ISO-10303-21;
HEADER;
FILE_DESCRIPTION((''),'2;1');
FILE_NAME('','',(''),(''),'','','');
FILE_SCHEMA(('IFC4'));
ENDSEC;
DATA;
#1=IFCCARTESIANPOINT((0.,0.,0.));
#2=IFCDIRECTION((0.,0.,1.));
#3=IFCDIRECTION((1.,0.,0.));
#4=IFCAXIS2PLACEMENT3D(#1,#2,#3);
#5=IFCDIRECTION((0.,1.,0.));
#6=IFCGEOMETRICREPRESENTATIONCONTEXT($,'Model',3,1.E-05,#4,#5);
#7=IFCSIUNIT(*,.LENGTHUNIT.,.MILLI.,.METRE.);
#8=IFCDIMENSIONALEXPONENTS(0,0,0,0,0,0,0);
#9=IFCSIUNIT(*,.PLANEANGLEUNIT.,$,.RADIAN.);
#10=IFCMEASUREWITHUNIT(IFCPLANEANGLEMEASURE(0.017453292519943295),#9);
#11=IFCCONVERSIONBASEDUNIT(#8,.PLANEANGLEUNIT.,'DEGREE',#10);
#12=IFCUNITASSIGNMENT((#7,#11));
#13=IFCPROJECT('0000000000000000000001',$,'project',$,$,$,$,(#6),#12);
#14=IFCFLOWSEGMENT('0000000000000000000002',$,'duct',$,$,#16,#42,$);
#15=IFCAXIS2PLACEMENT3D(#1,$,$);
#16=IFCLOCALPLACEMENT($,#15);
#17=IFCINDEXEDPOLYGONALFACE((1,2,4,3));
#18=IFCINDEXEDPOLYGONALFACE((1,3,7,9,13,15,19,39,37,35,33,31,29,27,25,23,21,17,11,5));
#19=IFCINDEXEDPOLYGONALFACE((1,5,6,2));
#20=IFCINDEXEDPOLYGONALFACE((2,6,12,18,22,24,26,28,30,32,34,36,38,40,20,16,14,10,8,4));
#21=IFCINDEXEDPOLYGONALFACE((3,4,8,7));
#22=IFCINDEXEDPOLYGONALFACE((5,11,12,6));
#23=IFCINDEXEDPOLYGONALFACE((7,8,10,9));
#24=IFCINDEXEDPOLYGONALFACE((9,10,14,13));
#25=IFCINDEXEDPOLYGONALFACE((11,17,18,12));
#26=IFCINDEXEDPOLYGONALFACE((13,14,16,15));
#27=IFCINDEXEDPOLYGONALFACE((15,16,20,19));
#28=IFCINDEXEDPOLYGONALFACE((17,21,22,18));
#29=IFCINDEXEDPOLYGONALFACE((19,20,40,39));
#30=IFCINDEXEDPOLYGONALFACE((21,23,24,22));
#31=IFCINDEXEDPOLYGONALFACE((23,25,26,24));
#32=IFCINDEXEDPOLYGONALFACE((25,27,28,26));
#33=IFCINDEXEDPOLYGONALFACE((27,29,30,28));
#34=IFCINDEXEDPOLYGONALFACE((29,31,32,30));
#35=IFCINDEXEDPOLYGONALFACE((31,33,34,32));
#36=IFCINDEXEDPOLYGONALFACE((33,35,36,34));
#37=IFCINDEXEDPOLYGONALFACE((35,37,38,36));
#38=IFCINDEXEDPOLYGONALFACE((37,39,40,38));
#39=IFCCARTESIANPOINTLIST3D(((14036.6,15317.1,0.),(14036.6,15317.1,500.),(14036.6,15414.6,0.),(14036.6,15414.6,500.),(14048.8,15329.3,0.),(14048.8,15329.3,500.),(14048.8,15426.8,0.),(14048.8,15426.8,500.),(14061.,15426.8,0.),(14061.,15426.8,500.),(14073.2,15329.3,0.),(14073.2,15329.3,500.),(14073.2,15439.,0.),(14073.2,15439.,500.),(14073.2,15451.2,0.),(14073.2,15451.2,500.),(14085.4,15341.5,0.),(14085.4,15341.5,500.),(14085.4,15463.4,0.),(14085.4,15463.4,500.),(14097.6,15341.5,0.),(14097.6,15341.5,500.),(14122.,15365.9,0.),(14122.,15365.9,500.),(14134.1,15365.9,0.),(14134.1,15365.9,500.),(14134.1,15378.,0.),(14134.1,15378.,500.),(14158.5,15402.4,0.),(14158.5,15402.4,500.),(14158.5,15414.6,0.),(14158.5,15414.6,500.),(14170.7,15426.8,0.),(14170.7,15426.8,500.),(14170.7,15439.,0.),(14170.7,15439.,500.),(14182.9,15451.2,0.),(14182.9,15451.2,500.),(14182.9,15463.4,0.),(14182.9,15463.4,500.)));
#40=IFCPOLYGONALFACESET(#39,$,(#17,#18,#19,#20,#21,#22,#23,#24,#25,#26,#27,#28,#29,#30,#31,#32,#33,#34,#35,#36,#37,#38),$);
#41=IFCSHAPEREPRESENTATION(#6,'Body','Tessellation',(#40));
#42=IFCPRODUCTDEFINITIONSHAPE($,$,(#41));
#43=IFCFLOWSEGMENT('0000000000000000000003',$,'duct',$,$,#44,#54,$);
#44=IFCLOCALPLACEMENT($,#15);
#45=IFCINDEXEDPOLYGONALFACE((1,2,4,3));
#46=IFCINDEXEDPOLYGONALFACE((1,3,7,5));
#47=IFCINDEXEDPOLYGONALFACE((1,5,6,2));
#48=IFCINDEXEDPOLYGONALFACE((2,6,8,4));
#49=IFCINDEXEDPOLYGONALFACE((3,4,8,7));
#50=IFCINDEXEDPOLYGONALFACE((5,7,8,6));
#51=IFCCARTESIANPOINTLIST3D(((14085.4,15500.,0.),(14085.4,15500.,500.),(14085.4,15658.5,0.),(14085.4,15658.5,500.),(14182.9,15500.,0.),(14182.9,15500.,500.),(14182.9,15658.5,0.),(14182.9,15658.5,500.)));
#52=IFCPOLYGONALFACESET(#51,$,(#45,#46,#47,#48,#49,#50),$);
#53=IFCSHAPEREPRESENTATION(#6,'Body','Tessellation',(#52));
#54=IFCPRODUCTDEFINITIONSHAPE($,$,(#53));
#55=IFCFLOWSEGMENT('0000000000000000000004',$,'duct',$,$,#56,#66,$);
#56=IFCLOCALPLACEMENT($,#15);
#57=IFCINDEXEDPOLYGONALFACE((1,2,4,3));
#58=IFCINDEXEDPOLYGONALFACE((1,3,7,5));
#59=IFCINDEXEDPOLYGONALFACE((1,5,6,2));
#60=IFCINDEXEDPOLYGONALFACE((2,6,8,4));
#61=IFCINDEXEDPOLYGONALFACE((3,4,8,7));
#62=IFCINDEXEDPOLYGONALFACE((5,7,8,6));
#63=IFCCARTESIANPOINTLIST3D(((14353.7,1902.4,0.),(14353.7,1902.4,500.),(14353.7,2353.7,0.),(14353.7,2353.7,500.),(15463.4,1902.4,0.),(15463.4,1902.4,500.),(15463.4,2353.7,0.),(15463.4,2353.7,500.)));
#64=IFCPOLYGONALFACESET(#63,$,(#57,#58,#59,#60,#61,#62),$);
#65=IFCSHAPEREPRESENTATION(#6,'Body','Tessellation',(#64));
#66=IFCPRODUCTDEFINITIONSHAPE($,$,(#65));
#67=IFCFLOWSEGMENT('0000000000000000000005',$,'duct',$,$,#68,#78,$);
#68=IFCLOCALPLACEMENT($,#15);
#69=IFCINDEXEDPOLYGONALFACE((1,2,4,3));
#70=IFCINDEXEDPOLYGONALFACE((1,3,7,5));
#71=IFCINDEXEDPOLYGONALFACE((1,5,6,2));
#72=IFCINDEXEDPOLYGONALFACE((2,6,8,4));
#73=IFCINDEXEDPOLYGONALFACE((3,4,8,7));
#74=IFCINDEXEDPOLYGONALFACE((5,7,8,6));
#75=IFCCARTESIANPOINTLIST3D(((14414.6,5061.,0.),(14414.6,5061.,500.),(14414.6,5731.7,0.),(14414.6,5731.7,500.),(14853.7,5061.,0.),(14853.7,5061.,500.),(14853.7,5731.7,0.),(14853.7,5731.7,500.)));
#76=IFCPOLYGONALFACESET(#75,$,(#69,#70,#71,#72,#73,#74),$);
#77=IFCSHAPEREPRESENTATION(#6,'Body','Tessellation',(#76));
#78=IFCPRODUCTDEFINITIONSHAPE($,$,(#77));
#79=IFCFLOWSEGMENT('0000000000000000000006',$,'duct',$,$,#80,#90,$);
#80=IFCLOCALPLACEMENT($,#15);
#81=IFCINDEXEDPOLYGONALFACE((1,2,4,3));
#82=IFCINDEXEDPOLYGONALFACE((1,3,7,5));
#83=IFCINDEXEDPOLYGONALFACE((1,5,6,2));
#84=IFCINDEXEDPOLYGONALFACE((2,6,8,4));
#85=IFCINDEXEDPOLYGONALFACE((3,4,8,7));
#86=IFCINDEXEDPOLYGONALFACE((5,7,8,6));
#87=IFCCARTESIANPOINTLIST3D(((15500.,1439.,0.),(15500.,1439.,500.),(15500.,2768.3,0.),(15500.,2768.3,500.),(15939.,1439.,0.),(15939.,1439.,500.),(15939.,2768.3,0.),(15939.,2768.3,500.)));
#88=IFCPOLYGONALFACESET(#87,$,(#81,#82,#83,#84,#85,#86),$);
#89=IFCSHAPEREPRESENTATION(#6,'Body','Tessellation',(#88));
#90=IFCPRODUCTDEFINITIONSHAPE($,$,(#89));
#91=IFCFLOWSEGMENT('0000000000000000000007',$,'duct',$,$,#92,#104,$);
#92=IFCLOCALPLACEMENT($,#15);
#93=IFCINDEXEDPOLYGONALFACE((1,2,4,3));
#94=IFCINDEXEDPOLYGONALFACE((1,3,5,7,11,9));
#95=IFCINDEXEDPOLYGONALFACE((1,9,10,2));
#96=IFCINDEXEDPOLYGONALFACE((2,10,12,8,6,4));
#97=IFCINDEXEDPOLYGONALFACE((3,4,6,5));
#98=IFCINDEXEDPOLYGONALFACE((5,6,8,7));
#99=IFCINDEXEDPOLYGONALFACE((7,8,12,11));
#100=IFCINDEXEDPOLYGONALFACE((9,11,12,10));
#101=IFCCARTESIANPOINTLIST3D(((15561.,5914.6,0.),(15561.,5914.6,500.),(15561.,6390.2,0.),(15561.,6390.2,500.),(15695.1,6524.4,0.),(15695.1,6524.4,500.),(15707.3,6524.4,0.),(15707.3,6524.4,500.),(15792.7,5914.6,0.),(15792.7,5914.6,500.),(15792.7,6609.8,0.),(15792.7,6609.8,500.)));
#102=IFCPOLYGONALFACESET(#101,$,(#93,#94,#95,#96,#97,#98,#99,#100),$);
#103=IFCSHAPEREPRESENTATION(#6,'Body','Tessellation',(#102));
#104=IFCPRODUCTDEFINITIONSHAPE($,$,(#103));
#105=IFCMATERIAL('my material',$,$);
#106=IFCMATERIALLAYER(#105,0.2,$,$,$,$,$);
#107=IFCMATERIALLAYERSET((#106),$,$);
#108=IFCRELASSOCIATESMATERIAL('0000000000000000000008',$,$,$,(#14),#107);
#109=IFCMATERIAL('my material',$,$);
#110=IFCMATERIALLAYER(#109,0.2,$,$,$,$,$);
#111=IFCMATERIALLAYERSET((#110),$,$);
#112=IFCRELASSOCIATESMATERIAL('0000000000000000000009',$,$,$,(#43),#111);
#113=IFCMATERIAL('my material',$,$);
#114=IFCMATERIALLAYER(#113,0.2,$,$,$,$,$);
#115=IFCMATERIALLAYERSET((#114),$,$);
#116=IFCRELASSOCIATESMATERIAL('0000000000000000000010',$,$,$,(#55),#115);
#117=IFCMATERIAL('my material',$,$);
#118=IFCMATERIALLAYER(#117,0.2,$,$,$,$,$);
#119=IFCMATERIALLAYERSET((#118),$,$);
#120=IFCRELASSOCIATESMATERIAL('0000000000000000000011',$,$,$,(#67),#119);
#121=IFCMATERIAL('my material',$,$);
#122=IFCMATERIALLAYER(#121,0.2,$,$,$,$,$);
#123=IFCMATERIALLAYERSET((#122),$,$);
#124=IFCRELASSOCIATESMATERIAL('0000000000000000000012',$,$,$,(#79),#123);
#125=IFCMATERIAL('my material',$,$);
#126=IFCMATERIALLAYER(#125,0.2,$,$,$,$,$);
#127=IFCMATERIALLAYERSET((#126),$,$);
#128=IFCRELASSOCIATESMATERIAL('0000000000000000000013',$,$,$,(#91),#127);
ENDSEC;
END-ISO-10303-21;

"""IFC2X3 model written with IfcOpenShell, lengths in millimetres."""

from ifc_helpers import new_model, entity, si_unit, converted_unit, direction, origin_with_axes, place, context, project, polyline, outline, extrude, material, layer, layer_set, layer_usage, element, save


model = new_model("IFC2X3")

# Units and contexts
model_context = context("Model", 3, precision=1e-05, world=origin_with_axes(), true_north=direction((0.0, 1.0, 0.0)))
ifc_project = project(units=[si_unit("LENGTHUNIT", "METRE", prefix="MILLI"), converted_unit("PLANEANGLEUNIT", "DEGREE", entity("IfcPlaneAngleMeasure", 0.017453292519943295), si_unit("PLANEANGLEUNIT", "RADIAN"), dimensions=[0, 0, 0, 0, 0, 0, 0])], contexts=[model_context])

# Flow segments
ifc_material_1 = material(Name="my material")
ifc_layer_1 = layer(ifc_material_1, 0.2)
ifc_layer_set_1 = layer_set([ifc_layer_1])
ifc_layer_usage_1 = layer_usage(ifc_layer_set_1, "AXIS2", "POSITIVE", -0.1)
flow_segment_1_placement = place(None, origin_with_axes())
element("IfcFlowSegment", 1, at=flow_segment_1_placement, material=ifc_layer_usage_1, Name="duct", context=model_context, shape_type="SweptSolid", body=[
    extrude(outline(polyline([(14036.6, 15317.1), (14048.8, 15329.3), (14073.2, 15329.3), (14085.4, 15341.5), (14097.6, 15341.5), (14122.0, 15365.9), (14134.1, 15365.9), (14134.1, 15378.0), (14158.5, 15402.4), (14158.5, 15414.6), (14170.7, 15426.8), (14170.7, 15439.0), (14182.9, 15451.2), (14182.9, 15463.4), (14085.4, 15463.4), (14073.2, 15451.2), (14073.2, 15439.0), (14061.0, 15426.8), (14048.8, 15426.8), (14036.6, 15414.6), (14036.6, 15317.1)])), origin_with_axes(), (0.0, 0.0, 1.0), 500.0),
])
ifc_material_2 = material(Name="my material")
ifc_layer_2 = layer(ifc_material_2, 0.2)
ifc_layer_set_2 = layer_set([ifc_layer_2])
ifc_layer_usage_2 = layer_usage(ifc_layer_set_2, "AXIS2", "POSITIVE", -0.1)
flow_segment_2_placement = place(None, origin_with_axes())
element("IfcFlowSegment", 2, at=flow_segment_2_placement, material=ifc_layer_usage_2, Name="duct", context=model_context, shape_type="SweptSolid", body=[
    extrude(outline(polyline([(14085.4, 15500.0), (14182.9, 15500.0), (14182.9, 15658.5), (14085.4, 15658.5), (14085.4, 15500.0)])), origin_with_axes(), (0.0, 0.0, 1.0), 500.0),
])
ifc_material_3 = material(Name="my material")
ifc_layer_3 = layer(ifc_material_3, 0.2)
ifc_layer_set_3 = layer_set([ifc_layer_3])
ifc_layer_usage_3 = layer_usage(ifc_layer_set_3, "AXIS2", "POSITIVE", -0.1)
flow_segment_3_placement = place(None, origin_with_axes())
element("IfcFlowSegment", 3, at=flow_segment_3_placement, material=ifc_layer_usage_3, Name="duct", context=model_context, shape_type="SweptSolid", body=[
    extrude(outline(polyline([(14353.7, 1902.4), (15463.4, 1902.4), (15463.4, 2353.7), (14353.7, 2353.7), (14353.7, 1902.4)])), origin_with_axes(), (0.0, 0.0, 1.0), 500.0),
])
ifc_material_4 = material(Name="my material")
ifc_layer_4 = layer(ifc_material_4, 0.2)
ifc_layer_set_4 = layer_set([ifc_layer_4])
ifc_layer_usage_4 = layer_usage(ifc_layer_set_4, "AXIS2", "POSITIVE", -0.1)
flow_segment_4_placement = place(None, origin_with_axes())
element("IfcFlowSegment", 4, at=flow_segment_4_placement, material=ifc_layer_usage_4, Name="duct", context=model_context, shape_type="SweptSolid", body=[
    extrude(outline(polyline([(14414.6, 5061.0), (14853.7, 5061.0), (14853.7, 5731.7), (14414.6, 5731.7), (14414.6, 5061.0)])), origin_with_axes(), (0.0, 0.0, 1.0), 500.0),
])
ifc_material_5 = material(Name="my material")
ifc_layer_5 = layer(ifc_material_5, 0.2)
ifc_layer_set_5 = layer_set([ifc_layer_5])
ifc_layer_usage_5 = layer_usage(ifc_layer_set_5, "AXIS2", "POSITIVE", -0.1)
flow_segment_5_placement = place(None, origin_with_axes())
element("IfcFlowSegment", 5, at=flow_segment_5_placement, material=ifc_layer_usage_5, Name="duct", context=model_context, shape_type="SweptSolid", body=[
    extrude(outline(polyline([(15500.0, 1439.0), (15939.0, 1439.0), (15939.0, 2768.3), (15500.0, 2768.3), (15500.0, 1439.0)])), origin_with_axes(), (0.0, 0.0, 1.0), 500.0),
])
ifc_material_6 = material(Name="my material")
ifc_layer_6 = layer(ifc_material_6, 0.2)
ifc_layer_set_6 = layer_set([ifc_layer_6])
ifc_layer_usage_6 = layer_usage(ifc_layer_set_6, "AXIS2", "POSITIVE", -0.1)
flow_segment_6_placement = place(None, origin_with_axes())
element("IfcFlowSegment", 6, at=flow_segment_6_placement, material=ifc_layer_usage_6, Name="duct", context=model_context, shape_type="SweptSolid", body=[
    extrude(outline(polyline([(15561.0, 5914.6), (15792.7, 5914.6), (15792.7, 6609.8), (15707.3, 6524.4), (15695.1, 6524.4), (15561.0, 6390.2), (15561.0, 5914.6)])), origin_with_axes(), (0.0, 0.0, 1.0), 500.0),
])

save(model, "model.ifc")
